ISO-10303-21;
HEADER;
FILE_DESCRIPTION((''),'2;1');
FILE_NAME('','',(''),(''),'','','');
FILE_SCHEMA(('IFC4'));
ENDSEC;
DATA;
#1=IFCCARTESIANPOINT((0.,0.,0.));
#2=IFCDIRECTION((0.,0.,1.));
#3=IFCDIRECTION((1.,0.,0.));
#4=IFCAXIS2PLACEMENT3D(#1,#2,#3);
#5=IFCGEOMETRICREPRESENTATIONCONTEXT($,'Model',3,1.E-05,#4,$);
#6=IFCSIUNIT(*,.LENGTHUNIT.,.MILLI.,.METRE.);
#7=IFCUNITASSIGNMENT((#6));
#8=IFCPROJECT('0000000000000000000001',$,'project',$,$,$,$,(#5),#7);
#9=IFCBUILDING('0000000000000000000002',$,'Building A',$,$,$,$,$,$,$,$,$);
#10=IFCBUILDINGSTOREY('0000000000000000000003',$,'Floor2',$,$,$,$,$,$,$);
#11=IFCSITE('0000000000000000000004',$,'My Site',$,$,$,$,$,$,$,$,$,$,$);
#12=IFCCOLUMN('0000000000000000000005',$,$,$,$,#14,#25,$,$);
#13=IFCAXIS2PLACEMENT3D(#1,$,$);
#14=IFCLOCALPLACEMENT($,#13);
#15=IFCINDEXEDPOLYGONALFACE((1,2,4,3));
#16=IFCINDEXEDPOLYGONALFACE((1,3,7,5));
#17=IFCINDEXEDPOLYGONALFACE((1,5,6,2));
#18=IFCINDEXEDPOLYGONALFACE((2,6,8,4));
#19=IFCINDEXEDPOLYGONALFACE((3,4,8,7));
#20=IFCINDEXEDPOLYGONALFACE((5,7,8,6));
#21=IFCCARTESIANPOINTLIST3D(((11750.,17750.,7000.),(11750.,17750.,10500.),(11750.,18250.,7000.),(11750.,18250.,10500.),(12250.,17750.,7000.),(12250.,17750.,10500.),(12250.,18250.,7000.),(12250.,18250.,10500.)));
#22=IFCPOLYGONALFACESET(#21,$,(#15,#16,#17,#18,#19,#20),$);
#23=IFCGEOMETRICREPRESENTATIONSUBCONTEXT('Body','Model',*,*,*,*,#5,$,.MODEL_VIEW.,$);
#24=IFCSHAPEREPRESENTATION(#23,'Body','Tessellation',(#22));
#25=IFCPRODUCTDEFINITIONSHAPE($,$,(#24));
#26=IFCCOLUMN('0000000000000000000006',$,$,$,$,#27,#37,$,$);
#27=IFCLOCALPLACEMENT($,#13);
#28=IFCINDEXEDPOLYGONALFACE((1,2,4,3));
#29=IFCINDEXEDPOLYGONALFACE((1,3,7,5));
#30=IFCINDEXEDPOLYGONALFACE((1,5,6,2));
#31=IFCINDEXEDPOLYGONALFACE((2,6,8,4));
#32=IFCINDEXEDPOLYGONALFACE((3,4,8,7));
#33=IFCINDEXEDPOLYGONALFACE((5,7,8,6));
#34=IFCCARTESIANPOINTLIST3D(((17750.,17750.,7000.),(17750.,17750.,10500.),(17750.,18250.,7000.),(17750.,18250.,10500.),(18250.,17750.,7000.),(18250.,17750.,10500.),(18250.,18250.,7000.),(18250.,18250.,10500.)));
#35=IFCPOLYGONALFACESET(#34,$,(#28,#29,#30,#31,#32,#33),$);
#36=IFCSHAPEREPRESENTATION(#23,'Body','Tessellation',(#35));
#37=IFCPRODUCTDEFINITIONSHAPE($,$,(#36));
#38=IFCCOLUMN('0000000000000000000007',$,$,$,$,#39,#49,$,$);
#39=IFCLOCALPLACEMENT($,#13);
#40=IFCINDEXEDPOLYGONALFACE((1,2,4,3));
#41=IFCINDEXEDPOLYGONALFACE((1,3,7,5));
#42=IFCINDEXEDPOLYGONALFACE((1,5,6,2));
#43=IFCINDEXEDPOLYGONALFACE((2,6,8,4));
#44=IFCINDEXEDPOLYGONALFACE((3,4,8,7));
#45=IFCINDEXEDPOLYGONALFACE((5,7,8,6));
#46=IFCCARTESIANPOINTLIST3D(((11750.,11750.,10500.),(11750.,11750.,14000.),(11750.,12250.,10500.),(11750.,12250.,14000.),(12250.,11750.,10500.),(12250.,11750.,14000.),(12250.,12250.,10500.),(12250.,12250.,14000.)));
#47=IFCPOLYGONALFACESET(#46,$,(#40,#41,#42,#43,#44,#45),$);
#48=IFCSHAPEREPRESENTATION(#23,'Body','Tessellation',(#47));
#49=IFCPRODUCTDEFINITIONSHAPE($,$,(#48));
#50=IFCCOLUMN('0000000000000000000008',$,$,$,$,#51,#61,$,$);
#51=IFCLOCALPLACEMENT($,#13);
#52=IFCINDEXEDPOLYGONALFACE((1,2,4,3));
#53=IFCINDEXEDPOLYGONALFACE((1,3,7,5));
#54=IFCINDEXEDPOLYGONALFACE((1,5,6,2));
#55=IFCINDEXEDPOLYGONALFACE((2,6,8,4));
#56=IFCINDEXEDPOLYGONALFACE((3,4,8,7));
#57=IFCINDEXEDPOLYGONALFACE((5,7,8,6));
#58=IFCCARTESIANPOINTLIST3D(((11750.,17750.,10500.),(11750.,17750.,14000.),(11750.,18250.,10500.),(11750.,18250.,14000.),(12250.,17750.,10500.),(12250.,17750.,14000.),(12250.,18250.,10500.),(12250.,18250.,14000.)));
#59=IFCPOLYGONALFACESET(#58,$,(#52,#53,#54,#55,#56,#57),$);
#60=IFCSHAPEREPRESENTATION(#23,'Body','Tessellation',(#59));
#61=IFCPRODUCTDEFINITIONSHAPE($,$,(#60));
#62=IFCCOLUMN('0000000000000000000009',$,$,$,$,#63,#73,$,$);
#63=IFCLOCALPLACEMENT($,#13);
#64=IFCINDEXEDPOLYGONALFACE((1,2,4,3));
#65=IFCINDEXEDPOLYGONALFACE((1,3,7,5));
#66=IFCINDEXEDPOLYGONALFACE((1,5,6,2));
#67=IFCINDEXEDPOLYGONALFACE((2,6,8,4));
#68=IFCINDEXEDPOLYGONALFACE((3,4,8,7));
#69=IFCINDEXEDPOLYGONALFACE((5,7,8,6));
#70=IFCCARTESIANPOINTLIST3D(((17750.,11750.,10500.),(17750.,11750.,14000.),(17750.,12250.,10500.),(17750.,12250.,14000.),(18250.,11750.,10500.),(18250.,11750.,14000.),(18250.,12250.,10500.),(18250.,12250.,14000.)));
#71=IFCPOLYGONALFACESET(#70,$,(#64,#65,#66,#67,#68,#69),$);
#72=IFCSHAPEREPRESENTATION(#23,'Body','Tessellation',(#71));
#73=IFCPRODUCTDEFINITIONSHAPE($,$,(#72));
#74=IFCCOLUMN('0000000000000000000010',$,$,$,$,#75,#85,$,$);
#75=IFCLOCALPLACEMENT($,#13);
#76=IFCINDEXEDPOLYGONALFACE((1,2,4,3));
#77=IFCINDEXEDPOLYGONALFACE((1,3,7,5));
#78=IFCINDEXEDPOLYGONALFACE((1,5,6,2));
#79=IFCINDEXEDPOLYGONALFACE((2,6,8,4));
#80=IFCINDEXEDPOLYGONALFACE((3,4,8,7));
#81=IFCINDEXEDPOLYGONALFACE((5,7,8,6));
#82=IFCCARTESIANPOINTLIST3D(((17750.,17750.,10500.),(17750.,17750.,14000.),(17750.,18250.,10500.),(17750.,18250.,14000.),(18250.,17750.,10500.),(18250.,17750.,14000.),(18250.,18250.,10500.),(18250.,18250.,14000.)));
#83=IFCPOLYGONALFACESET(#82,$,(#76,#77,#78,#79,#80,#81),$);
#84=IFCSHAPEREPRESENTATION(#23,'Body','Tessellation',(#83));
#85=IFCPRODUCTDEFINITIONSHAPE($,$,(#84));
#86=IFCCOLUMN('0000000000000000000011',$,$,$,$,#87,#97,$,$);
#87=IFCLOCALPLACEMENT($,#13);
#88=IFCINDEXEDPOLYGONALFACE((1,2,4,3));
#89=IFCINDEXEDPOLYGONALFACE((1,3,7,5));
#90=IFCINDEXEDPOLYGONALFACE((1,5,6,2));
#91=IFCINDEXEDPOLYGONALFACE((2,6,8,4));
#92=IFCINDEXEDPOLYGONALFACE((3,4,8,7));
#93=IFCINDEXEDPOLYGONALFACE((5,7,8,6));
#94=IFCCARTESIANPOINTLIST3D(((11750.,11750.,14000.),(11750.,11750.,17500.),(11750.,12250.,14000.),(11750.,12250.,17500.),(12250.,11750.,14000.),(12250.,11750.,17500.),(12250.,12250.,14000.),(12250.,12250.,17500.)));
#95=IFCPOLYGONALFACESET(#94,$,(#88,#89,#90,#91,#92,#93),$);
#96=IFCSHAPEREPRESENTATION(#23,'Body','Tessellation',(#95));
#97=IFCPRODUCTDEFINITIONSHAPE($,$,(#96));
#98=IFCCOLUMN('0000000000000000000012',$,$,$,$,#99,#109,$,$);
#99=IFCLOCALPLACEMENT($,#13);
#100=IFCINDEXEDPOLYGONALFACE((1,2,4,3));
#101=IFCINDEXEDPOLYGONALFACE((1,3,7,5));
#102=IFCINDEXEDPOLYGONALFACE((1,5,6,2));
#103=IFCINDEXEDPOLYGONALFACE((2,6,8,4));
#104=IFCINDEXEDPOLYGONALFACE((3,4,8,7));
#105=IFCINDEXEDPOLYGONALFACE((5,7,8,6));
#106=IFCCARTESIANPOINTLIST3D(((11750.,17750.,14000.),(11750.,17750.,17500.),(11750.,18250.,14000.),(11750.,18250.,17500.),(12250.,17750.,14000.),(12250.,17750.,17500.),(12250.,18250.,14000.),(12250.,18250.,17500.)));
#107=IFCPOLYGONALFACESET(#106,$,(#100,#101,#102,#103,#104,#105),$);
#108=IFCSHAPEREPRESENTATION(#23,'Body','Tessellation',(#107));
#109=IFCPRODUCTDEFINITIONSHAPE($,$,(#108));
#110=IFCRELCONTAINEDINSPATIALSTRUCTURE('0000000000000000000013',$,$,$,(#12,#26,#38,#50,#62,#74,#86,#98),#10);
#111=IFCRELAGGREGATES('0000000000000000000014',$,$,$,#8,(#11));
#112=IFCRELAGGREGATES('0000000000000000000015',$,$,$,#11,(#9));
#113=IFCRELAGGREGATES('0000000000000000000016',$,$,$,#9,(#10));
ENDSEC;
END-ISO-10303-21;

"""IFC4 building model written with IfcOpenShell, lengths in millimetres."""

from ifc_helpers import new_model, si_unit, frame, origin_with_axes, place, context, subcontext, project, spatial, line, indexed_curve, outline, extrude, element, save


model = new_model("IFC4")

# Units and contexts
model_context = context("Model", 3, precision=1e-05, world=origin_with_axes())
body_context = subcontext(model_context, "Body", "Model", "MODEL_VIEW")
ifc_project = project(units=[si_unit("LENGTHUNIT", "METRE", prefix="MILLI")], contexts=[model_context])

# Site, building, storey
site = spatial("IfcSite", under=ifc_project, Name="My Site")
building = spatial("IfcBuilding", under=site, Name="Building A")
storey = spatial("IfcBuildingStorey", under=building, Name="Floor2")

# Columns
for number, where, z_axis, x_axis in (
    (1, (12000.0, 18000.0, 7000.0), (0.0, 0.0, 1.0), (1.0, 0.0, 0.0)),
    (2, (18000.0, 18000.0, 7000.0), (0.0, 0.0, 1.0), (1.0, 0.0, 0.0)),
    (3, (12000.0, 12000.0, 10500.0), (0.0, 0.0, 1.0), (1.0, 0.0, 0.0)),
    (4, (12000.0, 18000.0, 10500.0), (0.0, 0.0, 1.0), (1.0, 0.0, 0.0)),
    (5, (18000.0, 12000.0, 10500.0), (0.0, 0.0, 1.0), (1.0, 0.0, 0.0)),
    (6, (18000.0, 18000.0, 10500.0), (0.0, 0.0, 1.0), (1.0, 0.0, 0.0)),
    (7, (12000.0, 12000.0, 14000.0), (0.0, 0.0, 1.0), (1.0, 0.0, 0.0)),
    (8, (12000.0, 18000.0, 14000.0), (0.0, 0.0, 1.0), (1.0, 0.0, 0.0)),
):
    element("IfcColumn", number, at=place(None, frame(where, z_axis=z_axis, x_axis=x_axis)), inside=storey, context=body_context, shape_type="SweptSolid", body=[
        extrude(outline(indexed_curve([(-250.0, -250.0), (250.0, -250.0), (250.0, 250.0), (-250.0, 250.0)], segments=[line(1, 2, 3, 4, 1)])), origin_with_axes(), (0.0, 0.0, 1.0), 3500.0),
    ])

save(model, "model.ifc")
